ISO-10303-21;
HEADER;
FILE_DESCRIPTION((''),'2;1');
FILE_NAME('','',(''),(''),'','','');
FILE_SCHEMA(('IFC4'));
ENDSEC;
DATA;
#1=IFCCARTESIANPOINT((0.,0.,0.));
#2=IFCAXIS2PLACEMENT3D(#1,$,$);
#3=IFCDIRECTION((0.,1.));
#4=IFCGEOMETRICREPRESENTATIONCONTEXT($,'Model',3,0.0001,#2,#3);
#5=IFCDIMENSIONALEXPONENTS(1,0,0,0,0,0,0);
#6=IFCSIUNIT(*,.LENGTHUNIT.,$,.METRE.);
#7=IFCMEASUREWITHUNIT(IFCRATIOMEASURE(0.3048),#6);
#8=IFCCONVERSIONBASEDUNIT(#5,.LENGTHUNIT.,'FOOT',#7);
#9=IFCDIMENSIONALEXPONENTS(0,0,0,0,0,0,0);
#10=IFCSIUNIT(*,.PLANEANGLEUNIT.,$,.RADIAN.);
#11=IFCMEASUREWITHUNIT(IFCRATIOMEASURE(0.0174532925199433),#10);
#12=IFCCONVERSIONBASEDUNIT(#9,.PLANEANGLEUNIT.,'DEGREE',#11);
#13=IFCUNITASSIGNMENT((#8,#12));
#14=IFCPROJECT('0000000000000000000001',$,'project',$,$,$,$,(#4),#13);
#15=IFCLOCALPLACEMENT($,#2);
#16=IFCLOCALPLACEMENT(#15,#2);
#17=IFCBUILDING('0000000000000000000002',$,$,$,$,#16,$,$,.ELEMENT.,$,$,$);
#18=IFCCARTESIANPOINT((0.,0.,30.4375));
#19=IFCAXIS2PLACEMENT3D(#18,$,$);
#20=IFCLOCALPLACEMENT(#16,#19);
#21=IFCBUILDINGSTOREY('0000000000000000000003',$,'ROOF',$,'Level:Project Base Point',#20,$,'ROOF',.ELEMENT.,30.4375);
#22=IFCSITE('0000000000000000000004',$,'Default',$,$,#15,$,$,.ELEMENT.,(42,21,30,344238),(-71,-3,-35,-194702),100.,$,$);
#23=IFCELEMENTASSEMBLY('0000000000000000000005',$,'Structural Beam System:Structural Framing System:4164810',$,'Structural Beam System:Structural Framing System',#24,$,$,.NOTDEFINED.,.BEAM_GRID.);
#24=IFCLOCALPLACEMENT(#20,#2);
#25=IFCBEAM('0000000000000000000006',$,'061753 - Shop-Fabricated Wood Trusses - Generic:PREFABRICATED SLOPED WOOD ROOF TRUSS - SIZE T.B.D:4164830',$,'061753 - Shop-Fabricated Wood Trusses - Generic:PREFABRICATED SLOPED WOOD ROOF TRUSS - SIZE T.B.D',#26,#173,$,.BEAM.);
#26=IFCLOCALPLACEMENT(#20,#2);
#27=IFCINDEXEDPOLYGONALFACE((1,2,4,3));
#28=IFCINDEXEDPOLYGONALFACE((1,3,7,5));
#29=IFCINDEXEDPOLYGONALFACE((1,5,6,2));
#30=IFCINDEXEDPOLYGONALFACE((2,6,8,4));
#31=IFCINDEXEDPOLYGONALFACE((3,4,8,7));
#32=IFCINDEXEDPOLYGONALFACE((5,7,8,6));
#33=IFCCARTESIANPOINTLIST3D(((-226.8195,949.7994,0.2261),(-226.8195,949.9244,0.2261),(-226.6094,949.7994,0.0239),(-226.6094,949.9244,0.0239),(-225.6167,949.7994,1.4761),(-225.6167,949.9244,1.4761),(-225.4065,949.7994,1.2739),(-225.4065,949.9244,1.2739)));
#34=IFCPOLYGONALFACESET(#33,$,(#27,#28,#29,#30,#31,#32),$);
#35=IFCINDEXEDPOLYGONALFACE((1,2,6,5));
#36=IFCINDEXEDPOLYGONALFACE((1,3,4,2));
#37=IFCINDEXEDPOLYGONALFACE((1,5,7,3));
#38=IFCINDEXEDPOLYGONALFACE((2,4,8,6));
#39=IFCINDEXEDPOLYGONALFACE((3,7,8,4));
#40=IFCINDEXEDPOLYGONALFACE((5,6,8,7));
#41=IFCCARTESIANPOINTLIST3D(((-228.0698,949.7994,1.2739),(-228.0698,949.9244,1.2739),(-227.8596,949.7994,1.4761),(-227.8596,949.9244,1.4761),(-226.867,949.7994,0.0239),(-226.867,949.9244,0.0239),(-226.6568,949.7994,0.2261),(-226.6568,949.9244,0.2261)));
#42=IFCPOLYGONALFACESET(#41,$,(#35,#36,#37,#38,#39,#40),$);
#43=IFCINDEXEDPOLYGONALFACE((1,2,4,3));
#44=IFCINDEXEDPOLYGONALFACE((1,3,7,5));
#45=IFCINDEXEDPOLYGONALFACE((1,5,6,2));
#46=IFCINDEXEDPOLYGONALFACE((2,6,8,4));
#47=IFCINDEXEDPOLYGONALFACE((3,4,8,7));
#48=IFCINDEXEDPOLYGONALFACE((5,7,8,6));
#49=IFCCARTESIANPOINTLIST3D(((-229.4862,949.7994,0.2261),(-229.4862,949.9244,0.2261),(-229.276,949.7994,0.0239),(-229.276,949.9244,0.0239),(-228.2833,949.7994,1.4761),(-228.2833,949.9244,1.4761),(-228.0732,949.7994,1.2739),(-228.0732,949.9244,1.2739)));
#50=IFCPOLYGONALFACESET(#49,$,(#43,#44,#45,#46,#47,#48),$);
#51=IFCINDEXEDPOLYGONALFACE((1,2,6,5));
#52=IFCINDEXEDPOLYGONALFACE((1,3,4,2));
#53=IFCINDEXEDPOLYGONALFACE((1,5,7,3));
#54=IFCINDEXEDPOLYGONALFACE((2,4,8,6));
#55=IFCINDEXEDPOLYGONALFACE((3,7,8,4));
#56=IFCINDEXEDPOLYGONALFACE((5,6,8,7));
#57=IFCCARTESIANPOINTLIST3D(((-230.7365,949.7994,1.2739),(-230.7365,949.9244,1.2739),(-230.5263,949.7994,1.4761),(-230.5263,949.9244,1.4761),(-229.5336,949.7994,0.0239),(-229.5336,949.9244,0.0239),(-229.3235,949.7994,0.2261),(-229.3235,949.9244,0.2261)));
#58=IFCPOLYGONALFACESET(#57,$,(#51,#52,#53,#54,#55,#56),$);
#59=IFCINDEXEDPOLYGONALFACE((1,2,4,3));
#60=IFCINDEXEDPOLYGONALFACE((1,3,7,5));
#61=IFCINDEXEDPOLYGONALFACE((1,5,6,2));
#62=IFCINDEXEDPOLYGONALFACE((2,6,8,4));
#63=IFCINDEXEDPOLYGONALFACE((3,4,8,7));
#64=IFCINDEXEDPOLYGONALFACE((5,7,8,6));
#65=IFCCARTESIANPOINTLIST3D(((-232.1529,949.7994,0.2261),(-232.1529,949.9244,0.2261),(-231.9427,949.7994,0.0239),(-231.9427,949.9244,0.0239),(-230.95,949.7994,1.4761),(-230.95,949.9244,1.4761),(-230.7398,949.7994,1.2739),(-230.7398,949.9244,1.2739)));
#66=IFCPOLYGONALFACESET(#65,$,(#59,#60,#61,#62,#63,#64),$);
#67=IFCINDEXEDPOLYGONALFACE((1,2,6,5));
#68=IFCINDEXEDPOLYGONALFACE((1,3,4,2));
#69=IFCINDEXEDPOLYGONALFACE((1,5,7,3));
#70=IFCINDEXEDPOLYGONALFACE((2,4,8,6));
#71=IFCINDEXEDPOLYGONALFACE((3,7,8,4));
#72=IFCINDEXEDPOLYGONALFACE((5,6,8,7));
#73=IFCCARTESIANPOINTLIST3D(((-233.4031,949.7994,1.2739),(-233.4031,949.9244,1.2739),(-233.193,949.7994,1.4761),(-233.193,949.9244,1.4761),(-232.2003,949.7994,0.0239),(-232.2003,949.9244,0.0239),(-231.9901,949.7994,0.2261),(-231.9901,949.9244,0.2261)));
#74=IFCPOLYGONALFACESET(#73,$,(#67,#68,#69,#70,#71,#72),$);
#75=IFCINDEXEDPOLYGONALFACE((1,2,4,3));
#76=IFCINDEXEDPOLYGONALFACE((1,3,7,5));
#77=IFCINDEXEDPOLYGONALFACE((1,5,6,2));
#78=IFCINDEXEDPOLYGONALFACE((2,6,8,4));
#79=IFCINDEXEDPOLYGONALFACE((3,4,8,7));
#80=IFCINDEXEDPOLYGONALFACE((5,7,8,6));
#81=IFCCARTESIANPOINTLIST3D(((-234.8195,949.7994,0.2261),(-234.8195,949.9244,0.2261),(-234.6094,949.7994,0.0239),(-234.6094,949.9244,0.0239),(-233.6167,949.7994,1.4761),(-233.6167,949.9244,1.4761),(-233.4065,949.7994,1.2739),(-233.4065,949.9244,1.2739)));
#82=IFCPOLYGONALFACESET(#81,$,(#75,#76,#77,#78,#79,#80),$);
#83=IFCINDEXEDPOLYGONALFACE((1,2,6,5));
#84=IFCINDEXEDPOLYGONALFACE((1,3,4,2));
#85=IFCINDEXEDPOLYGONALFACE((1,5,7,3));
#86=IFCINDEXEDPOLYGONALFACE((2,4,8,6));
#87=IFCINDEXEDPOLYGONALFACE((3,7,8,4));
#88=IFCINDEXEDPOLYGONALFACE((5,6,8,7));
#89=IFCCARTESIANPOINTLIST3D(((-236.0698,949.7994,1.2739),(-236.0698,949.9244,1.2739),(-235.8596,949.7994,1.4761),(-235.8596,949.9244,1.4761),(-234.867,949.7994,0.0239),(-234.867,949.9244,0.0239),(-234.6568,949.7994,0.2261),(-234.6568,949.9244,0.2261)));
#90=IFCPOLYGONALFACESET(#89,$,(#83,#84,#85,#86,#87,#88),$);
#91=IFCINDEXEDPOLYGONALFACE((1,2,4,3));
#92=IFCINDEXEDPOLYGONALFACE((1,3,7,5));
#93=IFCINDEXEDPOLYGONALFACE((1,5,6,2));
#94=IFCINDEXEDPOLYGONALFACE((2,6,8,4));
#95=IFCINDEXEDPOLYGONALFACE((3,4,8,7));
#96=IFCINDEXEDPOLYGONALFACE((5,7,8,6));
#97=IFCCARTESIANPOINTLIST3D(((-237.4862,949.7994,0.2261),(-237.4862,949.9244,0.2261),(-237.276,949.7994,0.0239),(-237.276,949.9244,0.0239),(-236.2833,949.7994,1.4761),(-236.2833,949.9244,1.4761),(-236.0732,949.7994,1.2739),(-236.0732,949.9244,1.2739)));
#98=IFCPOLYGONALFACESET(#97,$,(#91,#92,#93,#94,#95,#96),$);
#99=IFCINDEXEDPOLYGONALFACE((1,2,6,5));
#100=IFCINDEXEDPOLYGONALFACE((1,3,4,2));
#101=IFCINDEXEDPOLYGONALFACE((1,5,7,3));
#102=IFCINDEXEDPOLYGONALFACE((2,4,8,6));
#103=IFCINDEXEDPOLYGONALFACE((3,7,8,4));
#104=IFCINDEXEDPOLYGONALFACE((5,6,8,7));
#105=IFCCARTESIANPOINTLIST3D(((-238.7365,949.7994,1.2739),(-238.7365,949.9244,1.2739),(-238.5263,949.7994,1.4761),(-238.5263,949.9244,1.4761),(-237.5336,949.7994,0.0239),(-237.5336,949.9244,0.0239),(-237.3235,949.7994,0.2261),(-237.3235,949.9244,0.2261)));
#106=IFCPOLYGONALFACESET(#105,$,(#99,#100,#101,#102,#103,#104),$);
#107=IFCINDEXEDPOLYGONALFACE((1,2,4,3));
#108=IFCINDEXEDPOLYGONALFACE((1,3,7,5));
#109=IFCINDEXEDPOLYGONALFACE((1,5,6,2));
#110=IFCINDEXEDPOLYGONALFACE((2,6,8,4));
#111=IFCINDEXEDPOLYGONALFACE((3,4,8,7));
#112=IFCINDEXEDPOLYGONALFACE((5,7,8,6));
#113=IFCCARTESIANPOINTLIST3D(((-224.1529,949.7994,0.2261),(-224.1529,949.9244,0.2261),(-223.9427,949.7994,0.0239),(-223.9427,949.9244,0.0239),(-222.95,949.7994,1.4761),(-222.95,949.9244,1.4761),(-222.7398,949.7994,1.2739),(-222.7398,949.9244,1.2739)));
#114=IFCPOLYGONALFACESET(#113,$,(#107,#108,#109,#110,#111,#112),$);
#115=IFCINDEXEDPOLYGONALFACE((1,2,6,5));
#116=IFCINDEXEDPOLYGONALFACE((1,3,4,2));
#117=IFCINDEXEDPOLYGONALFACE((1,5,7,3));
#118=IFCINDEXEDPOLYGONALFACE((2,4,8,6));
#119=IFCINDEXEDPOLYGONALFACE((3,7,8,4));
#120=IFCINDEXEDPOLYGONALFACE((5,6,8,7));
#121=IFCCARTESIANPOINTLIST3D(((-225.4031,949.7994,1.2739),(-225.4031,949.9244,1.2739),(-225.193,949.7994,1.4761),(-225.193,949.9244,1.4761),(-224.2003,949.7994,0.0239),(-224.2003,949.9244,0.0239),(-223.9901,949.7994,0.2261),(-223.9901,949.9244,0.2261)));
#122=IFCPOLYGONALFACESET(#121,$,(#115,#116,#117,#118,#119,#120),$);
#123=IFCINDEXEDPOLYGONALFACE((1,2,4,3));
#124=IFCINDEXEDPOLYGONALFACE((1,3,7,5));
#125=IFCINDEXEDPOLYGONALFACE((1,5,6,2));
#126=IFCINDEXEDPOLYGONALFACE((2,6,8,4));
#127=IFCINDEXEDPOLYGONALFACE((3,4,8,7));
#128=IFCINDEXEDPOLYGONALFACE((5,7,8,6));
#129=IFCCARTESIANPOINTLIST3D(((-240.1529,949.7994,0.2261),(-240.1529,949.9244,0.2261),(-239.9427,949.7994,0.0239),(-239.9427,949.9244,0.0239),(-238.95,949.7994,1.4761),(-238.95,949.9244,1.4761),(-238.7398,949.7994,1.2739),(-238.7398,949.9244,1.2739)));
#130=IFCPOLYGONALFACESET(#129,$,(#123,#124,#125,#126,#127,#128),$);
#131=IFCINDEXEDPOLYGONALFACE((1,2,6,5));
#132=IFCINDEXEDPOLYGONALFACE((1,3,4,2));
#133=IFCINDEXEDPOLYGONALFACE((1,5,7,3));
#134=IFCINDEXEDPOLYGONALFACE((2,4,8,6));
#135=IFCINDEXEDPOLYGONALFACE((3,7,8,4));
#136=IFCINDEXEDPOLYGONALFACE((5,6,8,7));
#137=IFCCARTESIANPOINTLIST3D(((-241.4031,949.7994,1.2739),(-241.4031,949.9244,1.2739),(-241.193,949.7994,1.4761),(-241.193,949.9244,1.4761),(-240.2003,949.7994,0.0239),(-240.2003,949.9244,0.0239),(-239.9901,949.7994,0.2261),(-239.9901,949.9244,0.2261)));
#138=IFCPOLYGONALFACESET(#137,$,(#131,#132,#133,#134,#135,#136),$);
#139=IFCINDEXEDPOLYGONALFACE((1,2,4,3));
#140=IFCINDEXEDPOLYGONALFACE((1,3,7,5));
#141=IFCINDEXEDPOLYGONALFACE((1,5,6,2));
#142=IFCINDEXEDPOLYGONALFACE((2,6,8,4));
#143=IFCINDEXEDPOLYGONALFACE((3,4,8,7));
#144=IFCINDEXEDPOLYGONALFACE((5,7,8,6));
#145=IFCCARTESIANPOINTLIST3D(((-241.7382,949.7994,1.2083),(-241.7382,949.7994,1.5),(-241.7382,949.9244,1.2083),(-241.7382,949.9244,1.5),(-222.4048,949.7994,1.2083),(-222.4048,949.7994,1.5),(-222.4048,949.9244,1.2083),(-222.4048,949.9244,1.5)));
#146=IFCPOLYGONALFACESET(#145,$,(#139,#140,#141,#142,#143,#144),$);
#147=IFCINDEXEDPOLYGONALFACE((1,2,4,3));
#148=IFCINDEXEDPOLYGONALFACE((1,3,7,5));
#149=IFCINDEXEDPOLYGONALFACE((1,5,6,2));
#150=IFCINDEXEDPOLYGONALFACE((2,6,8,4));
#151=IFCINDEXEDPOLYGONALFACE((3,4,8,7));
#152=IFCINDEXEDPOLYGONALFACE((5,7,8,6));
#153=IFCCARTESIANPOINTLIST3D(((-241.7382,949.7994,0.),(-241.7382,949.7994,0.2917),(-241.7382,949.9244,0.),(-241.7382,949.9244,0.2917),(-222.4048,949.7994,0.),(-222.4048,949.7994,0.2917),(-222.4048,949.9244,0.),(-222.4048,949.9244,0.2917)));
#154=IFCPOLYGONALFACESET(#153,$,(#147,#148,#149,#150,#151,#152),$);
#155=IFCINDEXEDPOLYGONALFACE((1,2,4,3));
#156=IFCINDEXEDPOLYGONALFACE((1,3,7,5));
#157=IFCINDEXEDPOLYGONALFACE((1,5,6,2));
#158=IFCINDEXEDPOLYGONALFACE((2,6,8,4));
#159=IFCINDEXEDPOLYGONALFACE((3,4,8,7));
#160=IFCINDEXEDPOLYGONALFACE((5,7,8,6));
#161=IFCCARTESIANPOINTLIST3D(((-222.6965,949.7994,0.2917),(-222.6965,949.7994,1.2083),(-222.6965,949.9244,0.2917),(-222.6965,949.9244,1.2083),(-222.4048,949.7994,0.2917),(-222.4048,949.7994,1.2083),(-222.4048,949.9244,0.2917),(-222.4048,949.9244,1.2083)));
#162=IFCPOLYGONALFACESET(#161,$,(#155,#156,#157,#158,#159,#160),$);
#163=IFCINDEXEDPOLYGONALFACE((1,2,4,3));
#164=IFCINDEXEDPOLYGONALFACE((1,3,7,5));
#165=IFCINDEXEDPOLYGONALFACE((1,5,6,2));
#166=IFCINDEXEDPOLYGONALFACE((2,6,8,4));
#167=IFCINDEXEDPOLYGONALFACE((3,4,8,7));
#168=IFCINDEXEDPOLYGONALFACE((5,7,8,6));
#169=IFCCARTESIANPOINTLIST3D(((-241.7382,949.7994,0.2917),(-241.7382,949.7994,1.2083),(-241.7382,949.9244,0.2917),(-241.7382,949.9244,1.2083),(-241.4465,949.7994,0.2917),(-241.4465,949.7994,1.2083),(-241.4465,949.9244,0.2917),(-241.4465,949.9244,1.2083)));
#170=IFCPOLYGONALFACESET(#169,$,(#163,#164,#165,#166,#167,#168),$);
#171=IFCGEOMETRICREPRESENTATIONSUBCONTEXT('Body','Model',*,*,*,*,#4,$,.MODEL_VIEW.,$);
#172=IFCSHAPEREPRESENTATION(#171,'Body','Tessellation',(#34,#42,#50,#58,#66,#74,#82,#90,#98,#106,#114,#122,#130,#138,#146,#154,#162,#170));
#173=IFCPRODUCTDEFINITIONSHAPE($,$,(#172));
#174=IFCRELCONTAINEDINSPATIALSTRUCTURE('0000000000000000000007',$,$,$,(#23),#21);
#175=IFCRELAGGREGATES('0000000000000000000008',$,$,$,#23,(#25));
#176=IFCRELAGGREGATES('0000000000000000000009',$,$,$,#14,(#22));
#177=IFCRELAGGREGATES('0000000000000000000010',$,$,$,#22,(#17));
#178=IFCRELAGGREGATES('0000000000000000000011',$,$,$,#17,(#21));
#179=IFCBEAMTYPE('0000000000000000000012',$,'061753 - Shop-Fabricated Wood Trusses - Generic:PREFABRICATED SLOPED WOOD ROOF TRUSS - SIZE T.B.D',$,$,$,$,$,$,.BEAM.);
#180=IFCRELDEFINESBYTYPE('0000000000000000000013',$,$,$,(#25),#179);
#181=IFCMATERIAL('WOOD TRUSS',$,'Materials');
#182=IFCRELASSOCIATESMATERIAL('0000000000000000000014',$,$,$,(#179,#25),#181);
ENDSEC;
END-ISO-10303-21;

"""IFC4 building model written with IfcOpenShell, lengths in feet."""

from ifc_helpers import new_model, entity, si_unit, converted_unit, direction, frame, frame_2d, origin, origin_2d_with_axis, place, context, subcontext, project, spatial, rectangle, extrude, source, transform, mapped, material, material_profile, profile_set, profile_usage, type_object, type_shapes, element, aggregate, save


model = new_model("IFC4")

# Units and contexts
model_context = context("Model", 3, precision=0.0001, world=origin(), true_north=direction((0.0, 1.0)))
body_context = subcontext(model_context, "Body", "Model", "MODEL_VIEW")
ifc_project = project(units=[converted_unit("LENGTHUNIT", "FOOT", entity("IfcRatioMeasure", 0.3048), si_unit("LENGTHUNIT", "METRE"), dimensions=[1, 0, 0, 0, 0, 0, 0]), converted_unit("PLANEANGLEUNIT", "DEGREE", entity("IfcRatioMeasure", 0.0174532925199433), si_unit("PLANEANGLEUNIT", "RADIAN"), dimensions=[0, 0, 0, 0, 0, 0, 0])], contexts=[model_context])

# Site, building, storey
site_placement = place(None, origin())
site = spatial("IfcSite", under=ifc_project, at=site_placement, Name="Default", CompositionType="ELEMENT", RefLatitude=(42, 21, 30, 344238), RefLongitude=(-71, -3, -35, -194702), RefElevation=100.0)
building_placement = place(site_placement, origin())
building = spatial("IfcBuilding", under=site, at=building_placement, CompositionType="ELEMENT")
storey_placement = place(building_placement, frame((0.0, 0.0, 30.4375)))
storey = spatial("IfcBuildingStorey", under=building, at=storey_placement, Name="ROOF", ObjectType="Level:Project Base Point", LongName="ROOF", CompositionType="ELEMENT", Elevation=30.4375)

# Element assembly, beam
assembly_1_placement = place(storey_placement, origin())
assembly_1 = element("IfcElementAssembly", 1, at=assembly_1_placement, inside=storey, Name="Structural Beam System:Structural Framing System:4164810", ObjectType="Structural Beam System:Structural Framing System", AssemblyPlace="NOTDEFINED", PredefinedType="BEAM_GRID")
ifc_material_1 = material(Name="WOOD TRUSS", Category="Materials")
ifc_material_profile_1 = material_profile(ifc_material_1, rectangle(XDim=1.7347, YDim=0.125, at=origin_2d_with_axis()), Name="PREFABRICATED SLOPED WOOD ROOF TRUSS - SIZE T.B.D")
ifc_material_profile_2 = material_profile(ifc_material_1, rectangle(XDim=1.7347, YDim=0.125, at=frame_2d((0.0, 0.0), x_axis=(1.0, 0.0))), Name="PREFABRICATED SLOPED WOOD ROOF TRUSS - SIZE T.B.D")
ifc_material_profile_3 = material_profile(ifc_material_1, rectangle(XDim=1.7347, YDim=0.125, at=origin_2d_with_axis()), Name="PREFABRICATED SLOPED WOOD ROOF TRUSS - SIZE T.B.D")
ifc_material_profile_4 = material_profile(ifc_material_1, rectangle(XDim=1.7347, YDim=0.125, at=origin_2d_with_axis()), Name="PREFABRICATED SLOPED WOOD ROOF TRUSS - SIZE T.B.D")
ifc_material_profile_5 = material_profile(ifc_material_1, rectangle(XDim=1.7347, YDim=0.125, at=frame_2d((0.0, 0.0), x_axis=(1.0, 0.0))), Name="PREFABRICATED SLOPED WOOD ROOF TRUSS - SIZE T.B.D")
ifc_material_profile_6 = material_profile(ifc_material_1, rectangle(XDim=1.7347, YDim=0.125, at=frame_2d((0.0, 0.0), x_axis=(1.0, 0.0))), Name="PREFABRICATED SLOPED WOOD ROOF TRUSS - SIZE T.B.D")
ifc_material_profile_7 = material_profile(ifc_material_1, rectangle(XDim=1.7347, YDim=0.125, at=frame_2d((0.0, 0.0), x_axis=(1.0, 0.0))), Name="PREFABRICATED SLOPED WOOD ROOF TRUSS - SIZE T.B.D")
ifc_material_profile_8 = material_profile(ifc_material_1, rectangle(XDim=1.7347, YDim=0.125, at=frame_2d((0.0, 0.0), x_axis=(1.0, 0.0))), Name="PREFABRICATED SLOPED WOOD ROOF TRUSS - SIZE T.B.D")
ifc_material_profile_9 = material_profile(ifc_material_1, rectangle(XDim=1.7347, YDim=0.125, at=origin_2d_with_axis()), Name="PREFABRICATED SLOPED WOOD ROOF TRUSS - SIZE T.B.D")
ifc_material_profile_10 = material_profile(ifc_material_1, rectangle(XDim=1.7347, YDim=0.125, at=frame_2d((0.0, 0.0), x_axis=(1.0, 0.0))), Name="PREFABRICATED SLOPED WOOD ROOF TRUSS - SIZE T.B.D")
ifc_material_profile_11 = material_profile(ifc_material_1, rectangle(XDim=0.2917, YDim=0.125, at=frame_2d((0.0, 0.0), x_axis=(1.0, 0.0))), Name="PREFABRICATED SLOPED WOOD ROOF TRUSS - SIZE T.B.D")
ifc_material_profile_12 = material_profile(ifc_material_1, rectangle(XDim=0.2917, YDim=0.125, at=frame_2d((0.0, 0.0), x_axis=(1.0, 0.0))), Name="PREFABRICATED SLOPED WOOD ROOF TRUSS - SIZE T.B.D")
ifc_material_profile_13 = material_profile(ifc_material_1, rectangle(XDim=0.9167, YDim=0.125, at=frame_2d((0.0, 0.0), x_axis=(1.0, 0.0))), Name="PREFABRICATED SLOPED WOOD ROOF TRUSS - SIZE T.B.D")
ifc_material_profile_14 = material_profile(ifc_material_1, rectangle(XDim=0.9167, YDim=0.125, at=frame_2d((0.0, 0.0), x_axis=(1.0, 0.0))), Name="PREFABRICATED SLOPED WOOD ROOF TRUSS - SIZE T.B.D")
ifc_profile_set_1 = profile_set([ifc_material_profile_1, ifc_material_profile_2, ifc_material_profile_3, ifc_material_profile_4, ifc_material_profile_5, ifc_material_profile_6, ifc_material_profile_7, ifc_material_profile_8, ifc_material_profile_9, ifc_material_profile_10, ifc_material_profile_11, ifc_material_profile_12, ifc_material_profile_13, ifc_material_profile_14], Name="PREFABRICATED SLOPED WOOD ROOF TRUSS - SIZE T.B.D")
beam_type_1 = type_object("IfcBeamType", Name="061753 - Shop-Fabricated Wood Trusses - Generic:PREFABRICATED SLOPED WOOD ROOF TRUSS - SIZE T.B.D", PredefinedType="BEAM", material=ifc_profile_set_1)
shared_shape_1 = source(origin(), body_context, "Body", "SweptSolid", [
    extrude(rectangle(XDim=1.7347, YDim=0.125, at=frame_2d((0.0, 0.0), x_axis=(1.0, 0.0))), frame((5.8534, 0.0, 0.1011), z_axis=(0.720569, 0.0, -0.693383), x_axis=(0.693383, 0.0, 0.720569)), (0.0, 0.0, 1.0), 0.2917),
    extrude(rectangle(XDim=1.7347, YDim=0.125, at=frame_2d((0.0, 0.0), x_axis=(1.0, 0.0))), frame((4.6031, 0.0, -0.1011), z_axis=(0.720569, 0.0, 0.693383), x_axis=(0.693383, 0.0, -0.720569)), (0.0, 0.0, 1.0), 0.2917),
    extrude(rectangle(XDim=1.7347, YDim=0.125, at=frame_2d((0.0, 0.0), x_axis=(1.0, 0.0))), frame((3.1867, 0.0, 0.1011), z_axis=(0.720569, 0.0, -0.693383), x_axis=(0.693383, 0.0, 0.720569)), (0.0, 0.0, 1.0), 0.2917),
    extrude(rectangle(XDim=1.7347, YDim=0.125, at=frame_2d((0.0, 0.0), x_axis=(1.0, 0.0))), frame((1.9364, 0.0, -0.1011), z_axis=(0.720569, 0.0, 0.693383), x_axis=(0.693383, 0.0, -0.720569)), (0.0, 0.0, 1.0), 0.2917),
    extrude(rectangle(XDim=1.7347, YDim=0.125, at=frame_2d((0.0, 0.0), x_axis=(1.0, 0.0))), frame((0.5201, 0.0, 0.1011), z_axis=(0.720569, 0.0, -0.693383), x_axis=(0.693383, 0.0, 0.720569)), (0.0, 0.0, 1.0), 0.2917),
    extrude(rectangle(XDim=1.7347, YDim=0.125, at=origin_2d_with_axis()), frame((-0.7302, 0.0, -0.1011), z_axis=(0.720569, 0.0, 0.693383), x_axis=(0.693383, 0.0, -0.720569)), (0.0, 0.0, 1.0), 0.2917),
    extrude(rectangle(XDim=1.7347, YDim=0.125, at=frame_2d((0.0, 0.0), x_axis=(1.0, 0.0))), frame((-2.1466, 0.0, 0.1011), z_axis=(0.720569, 0.0, -0.693383), x_axis=(0.693383, 0.0, 0.720569)), (0.0, 0.0, 1.0), 0.2917),
    extrude(rectangle(XDim=1.7347, YDim=0.125, at=frame_2d((0.0, 0.0), x_axis=(1.0, 0.0))), frame((-3.3969, 0.0, -0.1011), z_axis=(0.720569, 0.0, 0.693383), x_axis=(0.693383, 0.0, -0.720569)), (0.0, 0.0, 1.0), 0.2917),
    extrude(rectangle(XDim=1.7347, YDim=0.125, at=origin_2d_with_axis()), frame((-4.8133, 0.0, 0.1011), z_axis=(0.720569, 0.0, -0.693383), x_axis=(0.693383, 0.0, 0.720569)), (0.0, 0.0, 1.0), 0.2917),
    extrude(rectangle(XDim=1.7347, YDim=0.125, at=frame_2d((0.0, 0.0), x_axis=(1.0, 0.0))), frame((-6.0636, 0.0, -0.1011), z_axis=(0.720569, 0.0, 0.693383), x_axis=(0.693383, 0.0, -0.720569)), (0.0, 0.0, 1.0), 0.2917),
    extrude(rectangle(XDim=1.7347, YDim=0.125, at=frame_2d((0.0, 0.0), x_axis=(1.0, 0.0))), frame((8.5201, 0.0, 0.1011), z_axis=(0.720569, 0.0, -0.693383), x_axis=(0.693383, 0.0, 0.720569)), (0.0, 0.0, 1.0), 0.2917),
    extrude(rectangle(XDim=1.7347, YDim=0.125, at=origin_2d_with_axis()), frame((7.2698, 0.0, -0.1011), z_axis=(0.720569, 0.0, 0.693383), x_axis=(0.693383, 0.0, -0.720569)), (0.0, 0.0, 1.0), 0.2917),
    extrude(rectangle(XDim=1.7347, YDim=0.125, at=frame_2d((0.0, 0.0), x_axis=(1.0, 0.0))), frame((-7.4799, 0.0, 0.1011), z_axis=(0.720569, 0.0, -0.693383), x_axis=(0.693383, 0.0, 0.720569)), (0.0, 0.0, 1.0), 0.2917),
    extrude(rectangle(XDim=1.7347, YDim=0.125, at=origin_2d_with_axis()), frame((-8.7302, 0.0, -0.1011), z_axis=(0.720569, 0.0, 0.693383), x_axis=(0.693383, 0.0, -0.720569)), (0.0, 0.0, 1.0), 0.2917),
    extrude(rectangle(XDim=0.2917, YDim=0.125, at=frame_2d((0.0, 0.0), x_axis=(1.0, 0.0))), frame((-9.6667, 0.0, 0.6042), z_axis=(1.0, 0.0, 0.0), x_axis=(0.0, 0.0, -1.0)), (0.0, 0.0, 1.0), 19.3333),
    extrude(rectangle(XDim=0.2917, YDim=0.125, at=frame_2d((0.0, 0.0), x_axis=(1.0, 0.0))), frame((-9.6667, 0.0, -0.6042), z_axis=(1.0, 0.0, 0.0), x_axis=(0.0, 0.0, -1.0)), (0.0, 0.0, 1.0), 19.3333),
    extrude(rectangle(XDim=0.9167, YDim=0.125, at=frame_2d((0.0, 0.0), x_axis=(1.0, 0.0))), frame((9.375, 0.0, 0.0), z_axis=(1.0, 0.0, 0.0), x_axis=(0.0, 0.0, -1.0)), (0.0, 0.0, 1.0), 0.2917),
    extrude(rectangle(XDim=0.9167, YDim=0.125, at=frame_2d((0.0, 0.0), x_axis=(1.0, 0.0))), frame((-9.6667, 0.0, 0.0), z_axis=(1.0, 0.0, 0.0), x_axis=(0.0, 0.0, -1.0)), (0.0, 0.0, 1.0), 0.2917),
])
type_shapes(beam_type_1, [shared_shape_1])
ifc_profile_usage_1 = profile_usage(ifc_profile_set_1, cardinal=8)
beam_1_placement = place(assembly_1_placement, frame((-232.0715, 949.8619, 0.75)))
beam_1 = element("IfcBeam", 2, at=beam_1_placement, type_object=beam_type_1, material=ifc_profile_usage_1, Name="061753 - Shop-Fabricated Wood Trusses - Generic:PREFABRICATED SLOPED WOOD ROOF TRUSS - SIZE T.B.D:4164830", ObjectType="061753 - Shop-Fabricated Wood Trusses - Generic:PREFABRICATED SLOPED WOOD ROOF TRUSS - SIZE T.B.D", PredefinedType="BEAM", context=body_context, shape_type="MappedRepresentation", body=[
    mapped(shared_shape_1, transform((0.0, 0.0, 0.0), scale=1.0)),
])
aggregate(assembly_1, [beam_1])

save(model, "model.ifc")
